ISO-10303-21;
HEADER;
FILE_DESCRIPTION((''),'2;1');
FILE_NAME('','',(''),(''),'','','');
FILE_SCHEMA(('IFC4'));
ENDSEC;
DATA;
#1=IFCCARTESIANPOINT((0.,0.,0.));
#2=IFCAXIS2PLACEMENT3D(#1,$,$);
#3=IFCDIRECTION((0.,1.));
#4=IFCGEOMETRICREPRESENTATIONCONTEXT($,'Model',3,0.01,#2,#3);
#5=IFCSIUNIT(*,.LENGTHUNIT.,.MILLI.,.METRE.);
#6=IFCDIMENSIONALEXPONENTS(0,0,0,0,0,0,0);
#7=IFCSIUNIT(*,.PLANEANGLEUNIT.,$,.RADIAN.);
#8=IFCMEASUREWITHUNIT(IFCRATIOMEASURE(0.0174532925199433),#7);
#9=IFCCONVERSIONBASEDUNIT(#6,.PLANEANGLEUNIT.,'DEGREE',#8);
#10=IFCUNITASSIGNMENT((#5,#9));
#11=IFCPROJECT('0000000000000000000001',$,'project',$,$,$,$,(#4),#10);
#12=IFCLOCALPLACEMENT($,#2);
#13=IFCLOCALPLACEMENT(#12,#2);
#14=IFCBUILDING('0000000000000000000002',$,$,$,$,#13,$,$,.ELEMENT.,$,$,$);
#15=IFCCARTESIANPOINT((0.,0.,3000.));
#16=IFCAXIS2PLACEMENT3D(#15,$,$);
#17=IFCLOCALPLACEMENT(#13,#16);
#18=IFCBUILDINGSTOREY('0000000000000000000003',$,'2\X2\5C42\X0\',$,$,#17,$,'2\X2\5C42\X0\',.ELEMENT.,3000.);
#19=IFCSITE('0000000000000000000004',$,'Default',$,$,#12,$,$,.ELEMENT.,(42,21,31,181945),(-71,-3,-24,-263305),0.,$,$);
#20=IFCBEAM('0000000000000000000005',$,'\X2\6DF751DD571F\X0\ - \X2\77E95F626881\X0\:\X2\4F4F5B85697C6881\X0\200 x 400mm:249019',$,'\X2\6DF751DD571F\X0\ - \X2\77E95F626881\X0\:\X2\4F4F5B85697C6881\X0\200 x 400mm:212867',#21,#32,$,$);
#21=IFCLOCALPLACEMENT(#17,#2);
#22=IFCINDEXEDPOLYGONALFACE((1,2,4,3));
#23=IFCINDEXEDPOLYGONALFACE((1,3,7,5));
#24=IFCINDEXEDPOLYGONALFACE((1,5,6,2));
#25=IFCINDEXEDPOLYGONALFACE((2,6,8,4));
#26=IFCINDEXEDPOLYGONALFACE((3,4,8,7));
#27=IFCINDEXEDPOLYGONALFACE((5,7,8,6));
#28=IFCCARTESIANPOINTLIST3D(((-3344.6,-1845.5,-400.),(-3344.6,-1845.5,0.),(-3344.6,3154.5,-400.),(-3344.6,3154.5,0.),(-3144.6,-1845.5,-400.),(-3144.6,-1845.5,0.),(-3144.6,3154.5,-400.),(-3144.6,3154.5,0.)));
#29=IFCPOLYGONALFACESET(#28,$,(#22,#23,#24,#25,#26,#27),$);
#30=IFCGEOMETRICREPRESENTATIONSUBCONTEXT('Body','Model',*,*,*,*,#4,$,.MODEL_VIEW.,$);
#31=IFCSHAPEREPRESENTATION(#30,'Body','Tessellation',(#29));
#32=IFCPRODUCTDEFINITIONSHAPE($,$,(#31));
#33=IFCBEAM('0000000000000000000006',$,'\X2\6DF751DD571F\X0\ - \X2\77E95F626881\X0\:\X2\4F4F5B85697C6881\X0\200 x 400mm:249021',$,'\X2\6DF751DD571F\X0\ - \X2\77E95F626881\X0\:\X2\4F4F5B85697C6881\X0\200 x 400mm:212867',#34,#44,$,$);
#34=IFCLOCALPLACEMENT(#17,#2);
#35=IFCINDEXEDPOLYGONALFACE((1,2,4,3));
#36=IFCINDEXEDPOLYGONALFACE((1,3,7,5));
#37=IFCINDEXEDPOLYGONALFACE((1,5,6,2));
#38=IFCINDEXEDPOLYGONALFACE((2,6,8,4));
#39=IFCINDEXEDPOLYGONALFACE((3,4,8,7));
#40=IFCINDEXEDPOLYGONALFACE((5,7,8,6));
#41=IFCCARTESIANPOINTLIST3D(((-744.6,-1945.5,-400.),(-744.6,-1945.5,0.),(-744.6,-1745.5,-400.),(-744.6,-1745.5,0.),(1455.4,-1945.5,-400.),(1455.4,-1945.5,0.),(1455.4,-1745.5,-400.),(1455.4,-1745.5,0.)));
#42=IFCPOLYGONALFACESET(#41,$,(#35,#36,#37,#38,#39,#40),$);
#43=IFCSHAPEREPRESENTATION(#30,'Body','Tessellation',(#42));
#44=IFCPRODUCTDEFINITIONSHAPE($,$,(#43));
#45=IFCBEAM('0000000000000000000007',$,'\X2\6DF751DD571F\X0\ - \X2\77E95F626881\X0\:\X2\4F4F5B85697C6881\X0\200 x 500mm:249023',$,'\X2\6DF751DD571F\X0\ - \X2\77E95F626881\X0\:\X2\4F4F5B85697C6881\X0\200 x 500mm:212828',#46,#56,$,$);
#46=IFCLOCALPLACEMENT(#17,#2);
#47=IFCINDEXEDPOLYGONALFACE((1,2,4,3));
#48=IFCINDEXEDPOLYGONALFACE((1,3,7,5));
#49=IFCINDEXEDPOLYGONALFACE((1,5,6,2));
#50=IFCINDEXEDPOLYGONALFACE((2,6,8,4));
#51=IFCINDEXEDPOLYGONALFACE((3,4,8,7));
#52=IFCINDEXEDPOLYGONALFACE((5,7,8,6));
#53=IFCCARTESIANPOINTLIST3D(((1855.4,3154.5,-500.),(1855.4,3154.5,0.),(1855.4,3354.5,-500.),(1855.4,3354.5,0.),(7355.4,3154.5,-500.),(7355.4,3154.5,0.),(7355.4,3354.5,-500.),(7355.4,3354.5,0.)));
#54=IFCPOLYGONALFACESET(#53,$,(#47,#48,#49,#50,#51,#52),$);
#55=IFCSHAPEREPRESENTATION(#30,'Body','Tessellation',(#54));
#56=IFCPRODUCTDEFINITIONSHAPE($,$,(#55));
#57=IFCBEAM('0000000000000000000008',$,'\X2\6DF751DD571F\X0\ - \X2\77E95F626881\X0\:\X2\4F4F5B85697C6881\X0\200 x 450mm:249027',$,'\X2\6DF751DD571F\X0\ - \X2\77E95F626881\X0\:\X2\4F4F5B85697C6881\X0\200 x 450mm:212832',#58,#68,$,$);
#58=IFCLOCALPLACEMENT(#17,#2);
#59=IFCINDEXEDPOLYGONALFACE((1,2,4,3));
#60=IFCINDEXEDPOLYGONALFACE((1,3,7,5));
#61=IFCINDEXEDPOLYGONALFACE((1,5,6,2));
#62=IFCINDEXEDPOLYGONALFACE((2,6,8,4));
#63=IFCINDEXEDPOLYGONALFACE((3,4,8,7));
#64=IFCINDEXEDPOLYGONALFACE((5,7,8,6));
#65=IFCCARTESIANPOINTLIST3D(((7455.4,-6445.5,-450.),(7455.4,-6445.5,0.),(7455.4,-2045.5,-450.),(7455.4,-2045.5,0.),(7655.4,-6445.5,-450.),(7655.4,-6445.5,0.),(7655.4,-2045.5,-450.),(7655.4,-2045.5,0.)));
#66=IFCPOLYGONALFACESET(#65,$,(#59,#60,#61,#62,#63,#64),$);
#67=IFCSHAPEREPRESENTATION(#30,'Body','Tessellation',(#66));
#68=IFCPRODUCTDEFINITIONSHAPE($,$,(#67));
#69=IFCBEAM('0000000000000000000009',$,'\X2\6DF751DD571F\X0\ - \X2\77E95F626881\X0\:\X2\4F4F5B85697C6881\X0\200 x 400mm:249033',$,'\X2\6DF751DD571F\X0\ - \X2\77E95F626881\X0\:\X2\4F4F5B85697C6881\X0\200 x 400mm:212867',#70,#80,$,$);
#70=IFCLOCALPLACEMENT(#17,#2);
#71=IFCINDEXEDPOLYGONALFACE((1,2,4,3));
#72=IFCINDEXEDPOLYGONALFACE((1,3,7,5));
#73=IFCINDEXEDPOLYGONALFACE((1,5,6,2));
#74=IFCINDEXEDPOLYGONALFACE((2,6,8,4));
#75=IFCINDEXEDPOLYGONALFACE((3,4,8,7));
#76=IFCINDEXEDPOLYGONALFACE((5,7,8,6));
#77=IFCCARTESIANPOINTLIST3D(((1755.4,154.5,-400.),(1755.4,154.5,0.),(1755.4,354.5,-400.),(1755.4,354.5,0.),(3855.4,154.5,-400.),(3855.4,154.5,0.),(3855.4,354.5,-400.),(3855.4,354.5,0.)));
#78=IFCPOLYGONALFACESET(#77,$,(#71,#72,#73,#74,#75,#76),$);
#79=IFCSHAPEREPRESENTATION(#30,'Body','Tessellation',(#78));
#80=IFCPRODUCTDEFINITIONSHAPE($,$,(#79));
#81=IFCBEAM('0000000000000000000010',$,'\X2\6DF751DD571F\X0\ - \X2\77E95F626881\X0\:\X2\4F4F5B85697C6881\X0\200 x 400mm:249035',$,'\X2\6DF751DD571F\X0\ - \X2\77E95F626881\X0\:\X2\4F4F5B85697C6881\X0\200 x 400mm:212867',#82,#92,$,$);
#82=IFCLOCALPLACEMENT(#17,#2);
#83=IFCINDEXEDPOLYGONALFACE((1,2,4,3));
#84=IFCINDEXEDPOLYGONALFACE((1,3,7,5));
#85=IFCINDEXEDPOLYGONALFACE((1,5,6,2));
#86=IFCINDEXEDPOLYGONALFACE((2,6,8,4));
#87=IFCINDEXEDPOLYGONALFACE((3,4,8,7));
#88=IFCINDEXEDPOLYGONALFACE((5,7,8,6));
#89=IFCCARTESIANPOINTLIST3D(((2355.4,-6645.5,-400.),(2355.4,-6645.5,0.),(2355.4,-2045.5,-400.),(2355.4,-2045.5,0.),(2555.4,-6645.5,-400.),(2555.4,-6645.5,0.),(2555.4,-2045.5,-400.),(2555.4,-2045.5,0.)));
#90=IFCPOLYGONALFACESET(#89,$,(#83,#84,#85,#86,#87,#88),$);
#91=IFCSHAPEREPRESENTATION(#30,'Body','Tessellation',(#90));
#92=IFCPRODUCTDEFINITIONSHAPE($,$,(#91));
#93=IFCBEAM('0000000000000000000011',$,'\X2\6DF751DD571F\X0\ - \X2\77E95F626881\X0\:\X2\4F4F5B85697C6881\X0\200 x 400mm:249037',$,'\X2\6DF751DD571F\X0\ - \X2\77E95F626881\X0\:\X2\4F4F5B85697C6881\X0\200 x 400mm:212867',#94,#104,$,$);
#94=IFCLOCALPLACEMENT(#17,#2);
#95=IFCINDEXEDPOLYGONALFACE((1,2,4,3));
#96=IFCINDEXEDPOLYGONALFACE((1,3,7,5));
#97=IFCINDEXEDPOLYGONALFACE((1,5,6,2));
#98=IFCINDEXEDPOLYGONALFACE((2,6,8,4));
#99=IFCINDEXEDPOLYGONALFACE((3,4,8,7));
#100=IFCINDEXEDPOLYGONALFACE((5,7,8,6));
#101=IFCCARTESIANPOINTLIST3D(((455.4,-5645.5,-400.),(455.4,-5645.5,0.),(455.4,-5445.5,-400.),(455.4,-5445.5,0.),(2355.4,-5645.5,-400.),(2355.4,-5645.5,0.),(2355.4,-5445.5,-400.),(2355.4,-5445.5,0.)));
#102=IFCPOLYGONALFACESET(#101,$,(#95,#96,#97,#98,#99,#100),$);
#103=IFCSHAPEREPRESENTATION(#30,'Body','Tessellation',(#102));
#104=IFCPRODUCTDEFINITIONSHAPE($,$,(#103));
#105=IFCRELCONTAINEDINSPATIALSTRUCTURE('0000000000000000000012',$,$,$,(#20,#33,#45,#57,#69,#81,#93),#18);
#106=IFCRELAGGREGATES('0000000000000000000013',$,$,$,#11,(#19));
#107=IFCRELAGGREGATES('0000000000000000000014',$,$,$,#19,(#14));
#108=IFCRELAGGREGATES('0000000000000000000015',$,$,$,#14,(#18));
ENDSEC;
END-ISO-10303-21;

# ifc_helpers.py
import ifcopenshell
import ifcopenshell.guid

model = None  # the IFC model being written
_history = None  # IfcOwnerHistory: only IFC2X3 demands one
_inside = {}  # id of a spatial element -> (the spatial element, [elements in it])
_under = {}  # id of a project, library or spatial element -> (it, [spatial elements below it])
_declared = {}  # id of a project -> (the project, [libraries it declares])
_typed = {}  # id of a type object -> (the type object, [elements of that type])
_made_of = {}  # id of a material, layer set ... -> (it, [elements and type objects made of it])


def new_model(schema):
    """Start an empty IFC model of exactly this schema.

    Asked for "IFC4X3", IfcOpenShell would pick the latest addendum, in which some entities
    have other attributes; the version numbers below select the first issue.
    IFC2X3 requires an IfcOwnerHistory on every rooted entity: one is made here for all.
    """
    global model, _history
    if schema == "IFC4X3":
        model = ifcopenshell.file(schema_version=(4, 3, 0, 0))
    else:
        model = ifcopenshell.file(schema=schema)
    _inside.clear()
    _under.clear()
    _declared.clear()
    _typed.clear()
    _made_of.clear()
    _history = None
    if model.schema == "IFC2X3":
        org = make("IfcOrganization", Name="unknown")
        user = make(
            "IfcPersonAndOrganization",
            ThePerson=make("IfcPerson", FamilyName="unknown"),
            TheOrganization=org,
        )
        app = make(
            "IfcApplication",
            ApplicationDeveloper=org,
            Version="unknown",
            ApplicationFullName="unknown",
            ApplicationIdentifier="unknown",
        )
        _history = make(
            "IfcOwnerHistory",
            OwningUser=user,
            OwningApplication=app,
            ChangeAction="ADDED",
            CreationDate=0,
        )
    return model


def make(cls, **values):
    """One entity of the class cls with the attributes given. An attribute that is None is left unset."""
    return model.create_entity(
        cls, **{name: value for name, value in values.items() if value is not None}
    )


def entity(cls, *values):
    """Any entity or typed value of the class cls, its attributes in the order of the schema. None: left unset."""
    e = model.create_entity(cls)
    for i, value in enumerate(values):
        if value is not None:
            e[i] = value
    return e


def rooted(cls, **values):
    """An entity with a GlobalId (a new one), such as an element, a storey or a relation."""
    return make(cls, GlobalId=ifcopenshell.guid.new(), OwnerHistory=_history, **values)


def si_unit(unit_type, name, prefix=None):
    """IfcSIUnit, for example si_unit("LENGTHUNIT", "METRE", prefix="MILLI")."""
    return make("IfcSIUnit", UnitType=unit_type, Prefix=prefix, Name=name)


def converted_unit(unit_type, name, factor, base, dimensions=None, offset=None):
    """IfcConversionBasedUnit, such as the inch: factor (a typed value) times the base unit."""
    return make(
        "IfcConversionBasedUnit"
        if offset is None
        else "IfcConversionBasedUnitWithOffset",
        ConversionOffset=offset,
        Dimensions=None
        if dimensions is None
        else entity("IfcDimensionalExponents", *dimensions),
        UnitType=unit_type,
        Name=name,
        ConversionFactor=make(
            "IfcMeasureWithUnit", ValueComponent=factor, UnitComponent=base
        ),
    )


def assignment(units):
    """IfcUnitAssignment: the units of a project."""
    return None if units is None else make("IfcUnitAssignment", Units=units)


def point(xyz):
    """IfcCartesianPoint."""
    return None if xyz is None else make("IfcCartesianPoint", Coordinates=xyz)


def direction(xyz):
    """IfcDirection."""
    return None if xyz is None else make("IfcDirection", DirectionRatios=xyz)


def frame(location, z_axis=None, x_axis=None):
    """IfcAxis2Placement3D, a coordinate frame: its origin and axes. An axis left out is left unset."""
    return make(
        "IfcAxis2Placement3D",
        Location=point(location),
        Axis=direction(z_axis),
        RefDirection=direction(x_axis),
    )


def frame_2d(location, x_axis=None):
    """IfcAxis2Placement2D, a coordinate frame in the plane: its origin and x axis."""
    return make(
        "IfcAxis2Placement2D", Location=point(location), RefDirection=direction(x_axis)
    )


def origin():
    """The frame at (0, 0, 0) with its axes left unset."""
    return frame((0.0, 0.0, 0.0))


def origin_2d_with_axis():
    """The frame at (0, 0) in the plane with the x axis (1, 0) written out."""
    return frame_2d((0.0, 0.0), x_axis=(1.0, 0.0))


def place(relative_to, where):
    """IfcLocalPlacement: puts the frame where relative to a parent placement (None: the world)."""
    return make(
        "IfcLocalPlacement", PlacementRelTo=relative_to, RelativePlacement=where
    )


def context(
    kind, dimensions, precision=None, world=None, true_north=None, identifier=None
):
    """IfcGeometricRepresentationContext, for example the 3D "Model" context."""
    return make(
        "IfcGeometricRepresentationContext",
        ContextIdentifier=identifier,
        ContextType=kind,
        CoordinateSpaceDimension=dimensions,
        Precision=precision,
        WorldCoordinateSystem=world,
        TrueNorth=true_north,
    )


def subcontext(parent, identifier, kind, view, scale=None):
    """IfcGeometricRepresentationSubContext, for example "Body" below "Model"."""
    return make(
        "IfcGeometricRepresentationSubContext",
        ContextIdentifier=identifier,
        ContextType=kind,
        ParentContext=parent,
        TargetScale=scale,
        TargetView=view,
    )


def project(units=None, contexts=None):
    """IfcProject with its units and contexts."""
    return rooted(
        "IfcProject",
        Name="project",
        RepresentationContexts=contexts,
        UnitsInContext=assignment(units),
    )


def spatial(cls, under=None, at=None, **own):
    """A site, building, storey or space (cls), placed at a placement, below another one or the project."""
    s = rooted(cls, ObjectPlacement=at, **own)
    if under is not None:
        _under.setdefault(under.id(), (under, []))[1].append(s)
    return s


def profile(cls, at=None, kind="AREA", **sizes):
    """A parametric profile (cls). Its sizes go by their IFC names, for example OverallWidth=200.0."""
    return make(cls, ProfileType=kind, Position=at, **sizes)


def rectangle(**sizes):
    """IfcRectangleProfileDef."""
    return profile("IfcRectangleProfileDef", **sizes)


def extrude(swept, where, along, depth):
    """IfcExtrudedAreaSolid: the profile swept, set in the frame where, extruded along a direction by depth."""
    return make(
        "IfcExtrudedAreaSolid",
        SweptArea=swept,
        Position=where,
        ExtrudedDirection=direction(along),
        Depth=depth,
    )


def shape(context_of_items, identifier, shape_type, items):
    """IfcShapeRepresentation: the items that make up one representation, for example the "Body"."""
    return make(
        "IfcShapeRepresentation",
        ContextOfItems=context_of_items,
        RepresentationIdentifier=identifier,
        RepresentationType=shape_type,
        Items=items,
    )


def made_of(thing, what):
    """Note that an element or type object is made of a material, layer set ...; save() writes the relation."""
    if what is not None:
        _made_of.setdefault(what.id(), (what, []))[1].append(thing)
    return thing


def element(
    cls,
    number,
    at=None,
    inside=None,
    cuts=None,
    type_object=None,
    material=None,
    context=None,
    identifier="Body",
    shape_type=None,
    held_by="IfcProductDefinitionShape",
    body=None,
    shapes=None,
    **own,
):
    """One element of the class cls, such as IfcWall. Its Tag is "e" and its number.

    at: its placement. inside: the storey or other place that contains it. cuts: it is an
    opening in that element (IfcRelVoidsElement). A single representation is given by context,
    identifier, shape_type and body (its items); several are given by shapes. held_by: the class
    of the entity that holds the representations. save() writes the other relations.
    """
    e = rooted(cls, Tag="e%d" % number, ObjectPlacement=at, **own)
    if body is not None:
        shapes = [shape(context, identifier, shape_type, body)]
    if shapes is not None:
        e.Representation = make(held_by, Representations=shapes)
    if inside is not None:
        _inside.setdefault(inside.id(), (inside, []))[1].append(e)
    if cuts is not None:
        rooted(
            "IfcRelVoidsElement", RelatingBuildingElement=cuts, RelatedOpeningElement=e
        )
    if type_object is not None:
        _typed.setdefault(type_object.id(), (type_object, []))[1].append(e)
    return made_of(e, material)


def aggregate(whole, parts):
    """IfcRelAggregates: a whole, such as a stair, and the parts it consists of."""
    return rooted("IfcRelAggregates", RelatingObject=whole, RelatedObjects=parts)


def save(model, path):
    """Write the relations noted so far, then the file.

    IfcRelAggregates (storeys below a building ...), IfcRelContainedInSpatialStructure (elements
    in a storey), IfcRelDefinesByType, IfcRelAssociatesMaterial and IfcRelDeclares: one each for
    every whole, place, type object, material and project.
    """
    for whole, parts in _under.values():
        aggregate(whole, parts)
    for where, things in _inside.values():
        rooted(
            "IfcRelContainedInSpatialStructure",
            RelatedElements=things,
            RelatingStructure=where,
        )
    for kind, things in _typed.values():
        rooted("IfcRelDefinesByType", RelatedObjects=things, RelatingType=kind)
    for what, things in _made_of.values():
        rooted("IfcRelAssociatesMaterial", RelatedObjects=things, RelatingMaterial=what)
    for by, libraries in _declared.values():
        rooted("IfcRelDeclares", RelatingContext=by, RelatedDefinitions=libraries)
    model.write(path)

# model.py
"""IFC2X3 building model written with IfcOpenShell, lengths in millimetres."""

from ifc_helpers import new_model, entity, si_unit, converted_unit, direction, frame, frame_2d, origin, origin_2d_with_axis, place, context, subcontext, project, spatial, rectangle, extrude, element, save


model = new_model("IFC2X3")

# Units and contexts
model_context = context("Model", 3, precision=0.01, world=origin(), true_north=direction((0.0, 1.0)))
body_context = subcontext(model_context, "Body", "Model", "MODEL_VIEW")
ifc_project = project(units=[si_unit("LENGTHUNIT", "METRE", prefix="MILLI"), converted_unit("PLANEANGLEUNIT", "DEGREE", entity("IfcRatioMeasure", 0.0174532925199433), si_unit("PLANEANGLEUNIT", "RADIAN"), dimensions=[0, 0, 0, 0, 0, 0, 0])], contexts=[model_context])

# Site, building, storey
site_placement = place(None, origin())
site = spatial("IfcSite", under=ifc_project, at=site_placement, Name="Default", CompositionType="ELEMENT", RefLatitude=(42, 21, 31, 181945), RefLongitude=(-71, -3, -24, -263305), RefElevation=0.0)
building_placement = place(site_placement, origin())
building = spatial("IfcBuilding", under=site, at=building_placement, CompositionType="ELEMENT")
storey_placement = place(building_placement, frame((0.0, 0.0, 3000.0)))
storey = spatial("IfcBuildingStorey", under=building, at=storey_placement, Name="2层", LongName="2层", CompositionType="ELEMENT", Elevation=3000.0)

# Beams
beam_1_placement = place(storey_placement, frame((-3244.6, 3254.5, 0.0), z_axis=(0.0, 0.0, 1.0), x_axis=(0.0, -1.0, 0.0)))
element("IfcBeam", 1, at=beam_1_placement, inside=storey, Name="混凝土 - 矩形梁:住宅楼梁200 x 400mm:249019", ObjectType="混凝土 - 矩形梁:住宅楼梁200 x 400mm:212867", context=body_context, shape_type="SweptSolid", body=[
    extrude(rectangle(XDim=400.0, YDim=200.0, at=origin_2d_with_axis()), frame((100.0, 0.0, -200.0), z_axis=(1.0, 0.0, 0.0), x_axis=(0.0, 0.0, -1.0)), (0.0, 0.0, 1.0), 5000.0),
])
beam_2_placement = place(storey_placement, frame((-944.6, -1845.5, 0.0)))
element("IfcBeam", 2, at=beam_2_placement, inside=storey, Name="混凝土 - 矩形梁:住宅楼梁200 x 400mm:249021", ObjectType="混凝土 - 矩形梁:住宅楼梁200 x 400mm:212867", context=body_context, shape_type="SweptSolid", body=[
    extrude(rectangle(XDim=400.0, YDim=200.0, at=frame_2d((0.0, 0.0), x_axis=(1.0, 0.0))), frame((200.0, 0.0, -200.0), z_axis=(1.0, 0.0, 0.0), x_axis=(0.0, 0.0, -1.0)), (0.0, 0.0, 1.0), 2200.0),
])
beam_3_placement = place(storey_placement, frame((7555.4, 3254.5, 0.0), z_axis=(0.0, 0.0, 1.0), x_axis=(-1.0, 0.0, 0.0)))
element("IfcBeam", 3, at=beam_3_placement, inside=storey, Name="混凝土 - 矩形梁:住宅楼梁200 x 500mm:249023", ObjectType="混凝土 - 矩形梁:住宅楼梁200 x 500mm:212828", context=body_context, shape_type="SweptSolid", body=[
    extrude(rectangle(XDim=500.0, YDim=200.0, at=frame_2d((0.0, 0.0), x_axis=(1.0, 0.0))), frame((200.0, 0.0, -250.0), z_axis=(1.0, 0.0, 0.0), x_axis=(0.0, 0.0, -1.0)), (0.0, 0.0, 1.0), 5500.0),
])
beam_4_placement = place(storey_placement, frame((7555.4, -1945.5, 0.0), z_axis=(0.0, 0.0, 1.0), x_axis=(0.0, -1.0, 0.0)))
element("IfcBeam", 4, at=beam_4_placement, inside=storey, Name="混凝土 - 矩形梁:住宅楼梁200 x 450mm:249027", ObjectType="混凝土 - 矩形梁:住宅楼梁200 x 450mm:212832", context=body_context, shape_type="SweptSolid", body=[
    extrude(rectangle(XDim=450.0, YDim=200.0, at=frame_2d((0.0, 0.0), x_axis=(1.0, 0.0))), frame((100.0, 0.0, -225.0), z_axis=(1.0, 0.0, 0.0), x_axis=(0.0, 0.0, -1.0)), (0.0, 0.0, 1.0), 4400.0),
])
beam_5_placement = place(storey_placement, frame((3955.4, 254.5, 0.0), z_axis=(0.0, 0.0, 1.0), x_axis=(-1.0, 0.0, 0.0)))
element("IfcBeam", 5, at=beam_5_placement, inside=storey, Name="混凝土 - 矩形梁:住宅楼梁200 x 400mm:249033", ObjectType="混凝土 - 矩形梁:住宅楼梁200 x 400mm:212867", context=body_context, shape_type="SweptSolid", body=[
    extrude(rectangle(XDim=400.0, YDim=200.0, at=frame_2d((0.0, 0.0), x_axis=(1.0, 0.0))), frame((100.0, 0.0, -200.0), z_axis=(1.0, 0.0, 0.0), x_axis=(0.0, 0.0, -1.0)), (0.0, 0.0, 1.0), 2100.0),
])
beam_6_placement = place(storey_placement, frame((2455.4, -1945.5, 0.0), z_axis=(0.0, 0.0, 1.0), x_axis=(0.0, -1.0, 0.0)))
element("IfcBeam", 6, at=beam_6_placement, inside=storey, Name="混凝土 - 矩形梁:住宅楼梁200 x 400mm:249035", ObjectType="混凝土 - 矩形梁:住宅楼梁200 x 400mm:212867", context=body_context, shape_type="SweptSolid", body=[
    extrude(rectangle(XDim=400.0, YDim=200.0, at=origin_2d_with_axis()), frame((100.0, 0.0, -200.0), z_axis=(1.0, 0.0, 0.0), x_axis=(0.0, 0.0, -1.0)), (0.0, 0.0, 1.0), 4600.0),
])
beam_7_placement = place(storey_placement, frame((2455.4, -5545.5, 0.0), z_axis=(0.0, 0.0, 1.0), x_axis=(-1.0, 0.0, 0.0)))
element("IfcBeam", 7, at=beam_7_placement, inside=storey, Name="混凝土 - 矩形梁:住宅楼梁200 x 400mm:249037", ObjectType="混凝土 - 矩形梁:住宅楼梁200 x 400mm:212867", context=body_context, shape_type="SweptSolid", body=[
    extrude(rectangle(XDim=400.0, YDim=200.0, at=frame_2d((0.0, 0.0), x_axis=(1.0, 0.0))), frame((100.0, 0.0, -200.0), z_axis=(1.0, 0.0, 0.0), x_axis=(0.0, 0.0, -1.0)), (0.0, 0.0, 1.0), 1900.0),
])

save(model, "model.ifc")
